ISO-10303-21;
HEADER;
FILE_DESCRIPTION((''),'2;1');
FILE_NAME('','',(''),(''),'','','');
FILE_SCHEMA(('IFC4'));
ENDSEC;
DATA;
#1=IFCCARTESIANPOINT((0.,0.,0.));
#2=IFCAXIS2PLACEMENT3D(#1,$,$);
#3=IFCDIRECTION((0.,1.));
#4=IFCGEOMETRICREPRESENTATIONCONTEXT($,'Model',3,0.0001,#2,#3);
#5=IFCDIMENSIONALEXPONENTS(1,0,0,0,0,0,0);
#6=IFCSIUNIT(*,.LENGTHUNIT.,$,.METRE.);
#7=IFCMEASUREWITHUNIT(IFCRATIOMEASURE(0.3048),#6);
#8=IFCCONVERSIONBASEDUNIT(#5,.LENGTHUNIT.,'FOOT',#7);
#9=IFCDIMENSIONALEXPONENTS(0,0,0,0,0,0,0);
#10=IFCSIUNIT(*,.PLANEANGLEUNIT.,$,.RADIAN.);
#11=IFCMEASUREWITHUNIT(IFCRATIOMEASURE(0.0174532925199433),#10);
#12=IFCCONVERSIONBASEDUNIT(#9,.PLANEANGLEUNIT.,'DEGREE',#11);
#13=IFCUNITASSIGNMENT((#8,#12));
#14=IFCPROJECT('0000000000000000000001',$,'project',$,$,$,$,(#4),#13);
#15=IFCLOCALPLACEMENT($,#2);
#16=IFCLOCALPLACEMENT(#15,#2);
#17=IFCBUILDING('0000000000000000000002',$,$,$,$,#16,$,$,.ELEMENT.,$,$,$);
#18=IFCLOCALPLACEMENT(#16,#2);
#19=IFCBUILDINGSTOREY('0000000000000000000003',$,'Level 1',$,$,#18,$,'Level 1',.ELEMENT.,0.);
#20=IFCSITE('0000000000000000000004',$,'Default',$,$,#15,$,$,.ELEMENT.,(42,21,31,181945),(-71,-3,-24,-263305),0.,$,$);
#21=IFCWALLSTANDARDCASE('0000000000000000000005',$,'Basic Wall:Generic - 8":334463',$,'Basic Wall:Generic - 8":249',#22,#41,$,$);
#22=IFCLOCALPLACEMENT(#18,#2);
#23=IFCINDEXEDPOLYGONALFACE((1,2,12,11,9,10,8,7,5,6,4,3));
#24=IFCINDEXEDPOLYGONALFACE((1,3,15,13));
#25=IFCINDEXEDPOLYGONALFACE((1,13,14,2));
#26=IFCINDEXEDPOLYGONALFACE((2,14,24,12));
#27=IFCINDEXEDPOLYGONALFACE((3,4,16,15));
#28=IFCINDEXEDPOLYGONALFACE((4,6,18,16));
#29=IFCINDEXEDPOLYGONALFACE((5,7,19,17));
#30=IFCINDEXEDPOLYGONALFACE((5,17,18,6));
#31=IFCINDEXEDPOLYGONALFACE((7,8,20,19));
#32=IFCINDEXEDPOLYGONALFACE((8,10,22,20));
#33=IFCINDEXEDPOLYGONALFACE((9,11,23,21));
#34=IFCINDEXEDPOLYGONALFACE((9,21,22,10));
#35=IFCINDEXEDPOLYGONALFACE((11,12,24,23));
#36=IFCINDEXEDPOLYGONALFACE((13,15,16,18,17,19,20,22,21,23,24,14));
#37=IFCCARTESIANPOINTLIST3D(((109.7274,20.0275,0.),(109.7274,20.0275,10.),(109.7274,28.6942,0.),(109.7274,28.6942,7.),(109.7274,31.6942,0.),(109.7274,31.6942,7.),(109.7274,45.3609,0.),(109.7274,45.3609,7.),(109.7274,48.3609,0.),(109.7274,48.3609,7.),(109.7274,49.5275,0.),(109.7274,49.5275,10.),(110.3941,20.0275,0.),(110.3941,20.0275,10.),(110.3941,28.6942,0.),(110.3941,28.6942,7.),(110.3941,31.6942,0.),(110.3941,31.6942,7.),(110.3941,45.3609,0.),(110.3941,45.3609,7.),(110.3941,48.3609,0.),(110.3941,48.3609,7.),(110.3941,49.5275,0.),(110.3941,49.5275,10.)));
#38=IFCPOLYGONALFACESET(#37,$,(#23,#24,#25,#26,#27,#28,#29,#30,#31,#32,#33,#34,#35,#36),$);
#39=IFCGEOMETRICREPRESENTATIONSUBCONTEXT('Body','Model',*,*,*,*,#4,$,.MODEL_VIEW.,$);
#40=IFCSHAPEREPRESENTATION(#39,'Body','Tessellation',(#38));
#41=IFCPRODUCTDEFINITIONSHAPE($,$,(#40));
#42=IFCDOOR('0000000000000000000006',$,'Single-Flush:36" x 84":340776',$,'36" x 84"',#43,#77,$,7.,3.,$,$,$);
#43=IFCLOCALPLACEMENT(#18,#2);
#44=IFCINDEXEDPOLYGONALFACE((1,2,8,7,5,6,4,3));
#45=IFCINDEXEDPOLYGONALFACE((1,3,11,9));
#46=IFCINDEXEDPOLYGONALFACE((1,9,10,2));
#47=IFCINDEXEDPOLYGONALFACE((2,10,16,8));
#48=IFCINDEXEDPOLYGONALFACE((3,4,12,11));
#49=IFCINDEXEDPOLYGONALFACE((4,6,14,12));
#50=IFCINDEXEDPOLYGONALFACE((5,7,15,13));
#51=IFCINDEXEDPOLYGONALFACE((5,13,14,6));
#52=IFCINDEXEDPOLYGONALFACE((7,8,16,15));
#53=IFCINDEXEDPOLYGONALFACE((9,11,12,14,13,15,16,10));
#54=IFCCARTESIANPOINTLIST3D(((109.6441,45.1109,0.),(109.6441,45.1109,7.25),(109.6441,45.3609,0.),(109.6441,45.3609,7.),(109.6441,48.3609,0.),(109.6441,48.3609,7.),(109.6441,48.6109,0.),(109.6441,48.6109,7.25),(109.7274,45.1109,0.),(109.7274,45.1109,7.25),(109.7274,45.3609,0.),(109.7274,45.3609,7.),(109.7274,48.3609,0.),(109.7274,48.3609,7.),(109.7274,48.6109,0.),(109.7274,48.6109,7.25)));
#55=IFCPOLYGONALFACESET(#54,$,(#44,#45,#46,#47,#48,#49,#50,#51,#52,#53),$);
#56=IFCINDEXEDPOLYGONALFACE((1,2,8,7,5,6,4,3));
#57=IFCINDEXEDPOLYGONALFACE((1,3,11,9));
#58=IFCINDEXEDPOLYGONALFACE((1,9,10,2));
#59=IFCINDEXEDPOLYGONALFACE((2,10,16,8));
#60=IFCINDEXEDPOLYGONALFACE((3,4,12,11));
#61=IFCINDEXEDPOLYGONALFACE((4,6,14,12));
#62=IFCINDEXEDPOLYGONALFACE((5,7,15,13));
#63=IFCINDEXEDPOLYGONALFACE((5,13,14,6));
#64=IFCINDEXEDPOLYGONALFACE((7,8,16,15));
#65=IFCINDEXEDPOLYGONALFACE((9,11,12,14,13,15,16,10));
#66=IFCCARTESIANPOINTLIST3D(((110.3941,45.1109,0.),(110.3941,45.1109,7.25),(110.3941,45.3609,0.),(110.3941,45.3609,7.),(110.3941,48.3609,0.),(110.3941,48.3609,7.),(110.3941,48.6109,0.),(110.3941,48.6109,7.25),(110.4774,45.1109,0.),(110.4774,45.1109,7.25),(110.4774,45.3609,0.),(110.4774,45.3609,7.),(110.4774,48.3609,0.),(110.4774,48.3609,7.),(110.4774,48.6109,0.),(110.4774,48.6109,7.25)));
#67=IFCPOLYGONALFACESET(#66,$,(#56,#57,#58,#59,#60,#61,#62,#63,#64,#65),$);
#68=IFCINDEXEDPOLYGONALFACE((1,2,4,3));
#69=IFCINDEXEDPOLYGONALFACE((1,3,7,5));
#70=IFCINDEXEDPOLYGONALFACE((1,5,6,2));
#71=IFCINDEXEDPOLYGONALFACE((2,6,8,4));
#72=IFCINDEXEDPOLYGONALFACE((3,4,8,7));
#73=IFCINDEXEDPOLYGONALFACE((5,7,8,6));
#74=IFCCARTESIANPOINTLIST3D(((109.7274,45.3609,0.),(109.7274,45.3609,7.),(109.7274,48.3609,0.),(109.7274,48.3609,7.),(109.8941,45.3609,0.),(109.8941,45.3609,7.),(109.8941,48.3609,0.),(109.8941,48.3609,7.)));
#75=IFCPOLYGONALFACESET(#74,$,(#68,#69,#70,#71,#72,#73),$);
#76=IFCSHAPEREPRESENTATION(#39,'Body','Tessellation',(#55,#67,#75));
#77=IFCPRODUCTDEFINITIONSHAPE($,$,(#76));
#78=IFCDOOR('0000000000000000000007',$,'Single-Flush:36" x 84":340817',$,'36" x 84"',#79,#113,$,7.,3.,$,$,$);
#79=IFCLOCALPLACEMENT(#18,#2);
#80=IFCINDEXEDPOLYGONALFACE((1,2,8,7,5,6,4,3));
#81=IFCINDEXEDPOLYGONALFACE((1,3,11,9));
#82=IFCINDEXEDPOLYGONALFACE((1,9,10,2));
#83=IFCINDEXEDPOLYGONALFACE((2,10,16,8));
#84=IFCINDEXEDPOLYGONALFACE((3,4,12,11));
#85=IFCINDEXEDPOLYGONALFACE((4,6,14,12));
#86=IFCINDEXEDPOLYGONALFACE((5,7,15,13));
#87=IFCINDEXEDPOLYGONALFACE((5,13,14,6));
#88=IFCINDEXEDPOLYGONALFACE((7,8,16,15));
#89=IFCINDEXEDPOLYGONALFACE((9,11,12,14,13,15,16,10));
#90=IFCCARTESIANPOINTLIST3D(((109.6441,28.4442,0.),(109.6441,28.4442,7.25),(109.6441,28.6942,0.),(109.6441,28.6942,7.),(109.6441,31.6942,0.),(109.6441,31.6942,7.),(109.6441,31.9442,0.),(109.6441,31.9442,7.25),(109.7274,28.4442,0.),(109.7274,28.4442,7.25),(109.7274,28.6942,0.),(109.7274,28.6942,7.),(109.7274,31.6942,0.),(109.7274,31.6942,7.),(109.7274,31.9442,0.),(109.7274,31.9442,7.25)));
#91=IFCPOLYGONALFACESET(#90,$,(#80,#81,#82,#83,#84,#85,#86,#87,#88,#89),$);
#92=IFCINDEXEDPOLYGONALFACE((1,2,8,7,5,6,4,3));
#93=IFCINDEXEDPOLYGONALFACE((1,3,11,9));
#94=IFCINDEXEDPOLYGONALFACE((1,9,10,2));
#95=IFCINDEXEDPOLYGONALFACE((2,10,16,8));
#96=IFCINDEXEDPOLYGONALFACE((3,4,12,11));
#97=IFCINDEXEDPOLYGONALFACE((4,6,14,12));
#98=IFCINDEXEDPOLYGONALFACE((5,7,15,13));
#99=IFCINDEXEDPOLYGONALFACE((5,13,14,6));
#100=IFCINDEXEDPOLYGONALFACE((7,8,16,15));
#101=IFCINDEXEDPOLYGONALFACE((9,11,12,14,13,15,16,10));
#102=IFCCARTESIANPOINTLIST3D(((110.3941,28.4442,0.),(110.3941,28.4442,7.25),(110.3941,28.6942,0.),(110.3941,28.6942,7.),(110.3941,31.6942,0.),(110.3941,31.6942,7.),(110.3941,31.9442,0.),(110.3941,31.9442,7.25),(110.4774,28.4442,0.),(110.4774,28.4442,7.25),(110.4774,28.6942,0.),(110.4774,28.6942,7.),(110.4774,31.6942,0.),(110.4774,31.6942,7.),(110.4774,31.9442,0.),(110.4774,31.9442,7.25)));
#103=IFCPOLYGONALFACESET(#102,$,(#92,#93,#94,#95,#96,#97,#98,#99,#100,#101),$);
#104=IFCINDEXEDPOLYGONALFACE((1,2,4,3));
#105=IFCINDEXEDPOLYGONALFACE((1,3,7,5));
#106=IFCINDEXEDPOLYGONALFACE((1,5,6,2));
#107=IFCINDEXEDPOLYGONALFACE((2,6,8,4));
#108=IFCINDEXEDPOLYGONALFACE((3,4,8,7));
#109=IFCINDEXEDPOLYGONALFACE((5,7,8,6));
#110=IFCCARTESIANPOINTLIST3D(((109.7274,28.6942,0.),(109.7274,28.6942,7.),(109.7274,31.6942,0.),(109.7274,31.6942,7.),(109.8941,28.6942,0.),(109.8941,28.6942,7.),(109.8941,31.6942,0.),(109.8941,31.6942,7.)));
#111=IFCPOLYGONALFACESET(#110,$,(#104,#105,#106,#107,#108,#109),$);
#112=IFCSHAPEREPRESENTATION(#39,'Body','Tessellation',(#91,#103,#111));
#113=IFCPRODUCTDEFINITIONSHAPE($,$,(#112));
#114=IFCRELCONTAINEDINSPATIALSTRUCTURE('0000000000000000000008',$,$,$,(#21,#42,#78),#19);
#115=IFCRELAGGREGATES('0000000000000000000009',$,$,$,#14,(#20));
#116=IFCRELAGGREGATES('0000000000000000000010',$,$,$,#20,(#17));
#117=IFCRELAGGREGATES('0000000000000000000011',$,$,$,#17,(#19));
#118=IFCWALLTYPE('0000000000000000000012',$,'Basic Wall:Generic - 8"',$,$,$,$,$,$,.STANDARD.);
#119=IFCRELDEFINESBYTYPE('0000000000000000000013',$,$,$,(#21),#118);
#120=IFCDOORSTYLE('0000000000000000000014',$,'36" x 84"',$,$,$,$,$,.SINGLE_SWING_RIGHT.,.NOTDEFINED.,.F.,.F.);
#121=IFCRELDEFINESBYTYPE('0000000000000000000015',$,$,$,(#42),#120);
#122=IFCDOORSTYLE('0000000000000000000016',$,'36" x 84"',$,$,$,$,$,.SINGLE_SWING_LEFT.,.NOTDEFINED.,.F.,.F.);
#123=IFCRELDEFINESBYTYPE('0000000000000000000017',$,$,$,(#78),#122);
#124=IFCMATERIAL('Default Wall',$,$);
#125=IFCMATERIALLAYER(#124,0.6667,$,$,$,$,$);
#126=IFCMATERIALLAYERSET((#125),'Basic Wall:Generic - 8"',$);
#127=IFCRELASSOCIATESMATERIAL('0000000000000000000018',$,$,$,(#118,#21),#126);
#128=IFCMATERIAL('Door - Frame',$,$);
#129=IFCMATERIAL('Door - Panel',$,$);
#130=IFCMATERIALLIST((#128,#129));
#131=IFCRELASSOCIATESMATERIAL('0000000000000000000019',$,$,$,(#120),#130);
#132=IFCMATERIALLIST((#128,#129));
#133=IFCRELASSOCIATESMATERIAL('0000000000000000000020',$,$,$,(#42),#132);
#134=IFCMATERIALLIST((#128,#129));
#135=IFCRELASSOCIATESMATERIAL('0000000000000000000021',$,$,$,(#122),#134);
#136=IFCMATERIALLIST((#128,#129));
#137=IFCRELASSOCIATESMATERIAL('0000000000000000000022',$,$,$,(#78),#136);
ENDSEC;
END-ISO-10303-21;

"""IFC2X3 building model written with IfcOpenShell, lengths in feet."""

from ifc_helpers import new_model, entity, si_unit, converted_unit, direction, frame, frame_2d, origin, place, context, subcontext, project, spatial, polyline, rectangle, outline, extrude, source, transform, mapped, material, material_list, layer, layer_set, layer_usage, type_object, type_shapes, element, fill, save


model = new_model("IFC2X3")

# Units and contexts
model_context = context("Model", 3, precision=0.0001, world=origin(), true_north=direction((0.0, 1.0)))
body_context = subcontext(model_context, "Body", "Model", "MODEL_VIEW")
ifc_project = project(units=[converted_unit("LENGTHUNIT", "FOOT", entity("IfcRatioMeasure", 0.3048), si_unit("LENGTHUNIT", "METRE"), dimensions=[1, 0, 0, 0, 0, 0, 0]), converted_unit("PLANEANGLEUNIT", "DEGREE", entity("IfcRatioMeasure", 0.0174532925199433), si_unit("PLANEANGLEUNIT", "RADIAN"), dimensions=[0, 0, 0, 0, 0, 0, 0])], contexts=[model_context])

# Site, building, storey
site_placement = place(None, origin())
site = spatial("IfcSite", under=ifc_project, at=site_placement, Name="Default", CompositionType="ELEMENT", RefLatitude=(42, 21, 31, 181945), RefLongitude=(-71, -3, -24, -263305), RefElevation=0.0)
building_placement = place(site_placement, origin())
building = spatial("IfcBuilding", under=site, at=building_placement, CompositionType="ELEMENT")
storey_placement = place(building_placement, origin())
storey = spatial("IfcBuildingStorey", under=building, at=storey_placement, Name="Level 1", LongName="Level 1", CompositionType="ELEMENT", Elevation=0.0)

# Shared definitions
ifc_material_1 = material(Name="Default Wall")
ifc_layer = layer(ifc_material_1, 0.6667)
ifc_layer_set = layer_set([ifc_layer], Name="Basic Wall:Generic - 8\"")
wall_type = type_object("IfcWallType", Name="Basic Wall:Generic - 8\"", PredefinedType="STANDARD", material=ifc_layer_set)

# Shared definitions
ifc_material_2 = material(Name="Door - Frame")
ifc_material_3 = material(Name="Door - Panel")
ifc_material_list_1 = material_list([ifc_material_2, ifc_material_3])
door_style_1 = type_object("IfcDoorStyle", Name="36\" x 84\"", ConstructionType="NOTDEFINED", OperationType="SINGLE_SWING_RIGHT", ParameterTakesPrecedence=False, Sizeable=False, material=ifc_material_list_1)
shared_shape_1 = source(origin(), body_context, "Body", "SweptSolid", [
    extrude(outline(polyline([(-1.75, -3.6875), (1.75, -3.6875), (1.75, 3.5625), (1.5, 3.5625), (1.5, -3.4375), (-1.5, -3.4375), (-1.5, 3.5625), (-1.75, 3.5625), (-1.75, -3.6875)])), frame((1.5, 0.6667, 3.5625), z_axis=(0.0, 1.0, 0.0), x_axis=(1.0, 0.0, 0.0)), (0.0, 0.0, 1.0), 0.0833),
    extrude(outline(polyline([(-3.6875, -1.75), (3.5625, -1.75), (3.5625, -1.5), (-3.4375, -1.5), (-3.4375, 1.5), (3.5625, 1.5), (3.5625, 1.75), (-3.6875, 1.75), (-3.6875, -1.75)])), frame((1.5, -0.0833, 3.5625), z_axis=(0.0, 1.0, 0.0), x_axis=(0.0, 0.0, -1.0)), (0.0, 0.0, 1.0), 0.0833),
    extrude(rectangle(XDim=0.1667, YDim=3.0, at=frame_2d((0.0, 0.0), x_axis=(1.0, 0.0))), frame((1.5, 0.5833, 0.0), z_axis=(0.0, 0.0, 1.0), x_axis=(0.0, 1.0, 0.0)), (0.0, 0.0, 1.0), 7.0),
])
type_shapes(door_style_1, [shared_shape_1])

# Wall, openings, doors
ifc_layer_usage_1 = layer_usage(ifc_layer_set, "AXIS2", "NEGATIVE", 0.3333)
wall_1_placement = place(storey_placement, frame((110.0608, 49.5275, 0.0), z_axis=(0.0, 0.0, 1.0), x_axis=(0.0, -1.0, 0.0)))
wall_1 = element("IfcWallStandardCase", 1, at=wall_1_placement, inside=storey, type_object=wall_type, material=ifc_layer_usage_1, Name="Basic Wall:Generic - 8\":334463", ObjectType="Basic Wall:Generic - 8\":249", context=body_context, shape_type="SweptSolid", body=[
    extrude(rectangle(XDim=29.5, YDim=0.6667, at=frame_2d((14.75, 0.0), x_axis=(-1.0, 0.0))), origin(), (0.0, 0.0, 1.0), 10.0),
])
opening_1_placement = place(wall_1_placement, frame((4.1667, 0.3333, 0.0)))
opening_1 = element("IfcOpeningElement", 2, at=opening_1_placement, cuts=wall_1, ObjectType="Opening", context=body_context, shape_type="SweptSolid", body=[
    extrude(rectangle(XDim=3.0, YDim=7.0, at=frame_2d((3.5, 1.5), x_axis=(0.0, 1.0))), frame((0.0, 0.0, 0.0), z_axis=(0.0, -1.0, 0.0), x_axis=(0.0, 0.0, 1.0)), (0.0, 0.0, 1.0), 0.6667),
])
opening_2_placement = place(wall_1_placement, frame((20.8333, 0.3333, 0.0)))
opening_2 = element("IfcOpeningElement", 3, at=opening_2_placement, cuts=wall_1, ObjectType="Opening", context=body_context, shape_type="SweptSolid", body=[
    extrude(rectangle(XDim=3.0, YDim=7.0, at=frame_2d((3.5, 1.5), x_axis=(0.0, -1.0))), frame((0.0, 0.0, 0.0), z_axis=(0.0, -1.0, 0.0), x_axis=(0.0, 0.0, 1.0)), (0.0, 0.0, 1.0), 0.6667),
])
ifc_material_list_2 = material_list([ifc_material_2, ifc_material_3])
door_1_placement = place(opening_1_placement, frame((0.0, 0.0, 0.0), z_axis=(0.0, 0.0, 1.0), x_axis=(-1.0, 0.0, 0.0)))
door_1 = element("IfcDoor", 4, at=door_1_placement, inside=storey, type_object=door_style_1, material=ifc_material_list_2, Name="Single-Flush:36\" x 84\":340776", ObjectType="36\" x 84\"", OverallHeight=7.0, OverallWidth=3.0, context=body_context, shape_type="MappedRepresentation", body=[
    mapped(shared_shape_1, transform((0.0, 0.0, 0.0), scale=1.0)),
])
fill(opening_1, door_1)
ifc_material_list_3 = material_list([ifc_material_2, ifc_material_3])
ifc_material_list_4 = material_list([ifc_material_2, ifc_material_3])
door_style_2 = type_object("IfcDoorStyle", Name="36\" x 84\"", ConstructionType="NOTDEFINED", OperationType="SINGLE_SWING_LEFT", ParameterTakesPrecedence=False, Sizeable=False, material=ifc_material_list_4)
shared_shape_2 = source(origin(), body_context, "Body", "SweptSolid", [
    extrude(outline(polyline([(-1.75, -3.6875), (1.75, -3.6875), (1.75, 3.5625), (1.5, 3.5625), (1.5, -3.4375), (-1.5, -3.4375), (-1.5, 3.5625), (-1.75, 3.5625), (-1.75, -3.6875)])), frame((1.5, 0.75, 3.5625), z_axis=(0.0, -1.0, 0.0), x_axis=(-1.0, 0.0, 0.0)), (0.0, 0.0, 1.0), 0.0833),
    extrude(outline(polyline([(-3.6875, -1.75), (3.5625, -1.75), (3.5625, -1.5), (-3.4375, -1.5), (-3.4375, 1.5), (3.5625, 1.5), (3.5625, 1.75), (-3.6875, 1.75), (-3.6875, -1.75)])), frame((1.5, 0.0, 3.5625), z_axis=(0.0, -1.0, 0.0), x_axis=(0.0, 0.0, -1.0)), (0.0, 0.0, 1.0), 0.0833),
    extrude(rectangle(XDim=3.0, YDim=0.1667, at=frame_2d((0.0, 0.0), x_axis=(1.0, 0.0))), frame((1.5, 0.5833, 0.0)), (0.0, 0.0, 1.0), 7.0),
])
type_shapes(door_style_2, [shared_shape_2])
door_2_placement = place(opening_2_placement, frame((0.0, 0.0, 0.0), z_axis=(0.0, 0.0, 1.0), x_axis=(-1.0, 0.0, 0.0)))
door_2 = element("IfcDoor", 5, at=door_2_placement, inside=storey, type_object=door_style_2, material=ifc_material_list_3, Name="Single-Flush:36\" x 84\":340817", ObjectType="36\" x 84\"", OverallHeight=7.0, OverallWidth=3.0, context=body_context, shape_type="MappedRepresentation", body=[
    mapped(shared_shape_2, transform((0.0, 0.0, 0.0), scale=1.0)),
])
fill(opening_2, door_2)

save(model, "model.ifc")
